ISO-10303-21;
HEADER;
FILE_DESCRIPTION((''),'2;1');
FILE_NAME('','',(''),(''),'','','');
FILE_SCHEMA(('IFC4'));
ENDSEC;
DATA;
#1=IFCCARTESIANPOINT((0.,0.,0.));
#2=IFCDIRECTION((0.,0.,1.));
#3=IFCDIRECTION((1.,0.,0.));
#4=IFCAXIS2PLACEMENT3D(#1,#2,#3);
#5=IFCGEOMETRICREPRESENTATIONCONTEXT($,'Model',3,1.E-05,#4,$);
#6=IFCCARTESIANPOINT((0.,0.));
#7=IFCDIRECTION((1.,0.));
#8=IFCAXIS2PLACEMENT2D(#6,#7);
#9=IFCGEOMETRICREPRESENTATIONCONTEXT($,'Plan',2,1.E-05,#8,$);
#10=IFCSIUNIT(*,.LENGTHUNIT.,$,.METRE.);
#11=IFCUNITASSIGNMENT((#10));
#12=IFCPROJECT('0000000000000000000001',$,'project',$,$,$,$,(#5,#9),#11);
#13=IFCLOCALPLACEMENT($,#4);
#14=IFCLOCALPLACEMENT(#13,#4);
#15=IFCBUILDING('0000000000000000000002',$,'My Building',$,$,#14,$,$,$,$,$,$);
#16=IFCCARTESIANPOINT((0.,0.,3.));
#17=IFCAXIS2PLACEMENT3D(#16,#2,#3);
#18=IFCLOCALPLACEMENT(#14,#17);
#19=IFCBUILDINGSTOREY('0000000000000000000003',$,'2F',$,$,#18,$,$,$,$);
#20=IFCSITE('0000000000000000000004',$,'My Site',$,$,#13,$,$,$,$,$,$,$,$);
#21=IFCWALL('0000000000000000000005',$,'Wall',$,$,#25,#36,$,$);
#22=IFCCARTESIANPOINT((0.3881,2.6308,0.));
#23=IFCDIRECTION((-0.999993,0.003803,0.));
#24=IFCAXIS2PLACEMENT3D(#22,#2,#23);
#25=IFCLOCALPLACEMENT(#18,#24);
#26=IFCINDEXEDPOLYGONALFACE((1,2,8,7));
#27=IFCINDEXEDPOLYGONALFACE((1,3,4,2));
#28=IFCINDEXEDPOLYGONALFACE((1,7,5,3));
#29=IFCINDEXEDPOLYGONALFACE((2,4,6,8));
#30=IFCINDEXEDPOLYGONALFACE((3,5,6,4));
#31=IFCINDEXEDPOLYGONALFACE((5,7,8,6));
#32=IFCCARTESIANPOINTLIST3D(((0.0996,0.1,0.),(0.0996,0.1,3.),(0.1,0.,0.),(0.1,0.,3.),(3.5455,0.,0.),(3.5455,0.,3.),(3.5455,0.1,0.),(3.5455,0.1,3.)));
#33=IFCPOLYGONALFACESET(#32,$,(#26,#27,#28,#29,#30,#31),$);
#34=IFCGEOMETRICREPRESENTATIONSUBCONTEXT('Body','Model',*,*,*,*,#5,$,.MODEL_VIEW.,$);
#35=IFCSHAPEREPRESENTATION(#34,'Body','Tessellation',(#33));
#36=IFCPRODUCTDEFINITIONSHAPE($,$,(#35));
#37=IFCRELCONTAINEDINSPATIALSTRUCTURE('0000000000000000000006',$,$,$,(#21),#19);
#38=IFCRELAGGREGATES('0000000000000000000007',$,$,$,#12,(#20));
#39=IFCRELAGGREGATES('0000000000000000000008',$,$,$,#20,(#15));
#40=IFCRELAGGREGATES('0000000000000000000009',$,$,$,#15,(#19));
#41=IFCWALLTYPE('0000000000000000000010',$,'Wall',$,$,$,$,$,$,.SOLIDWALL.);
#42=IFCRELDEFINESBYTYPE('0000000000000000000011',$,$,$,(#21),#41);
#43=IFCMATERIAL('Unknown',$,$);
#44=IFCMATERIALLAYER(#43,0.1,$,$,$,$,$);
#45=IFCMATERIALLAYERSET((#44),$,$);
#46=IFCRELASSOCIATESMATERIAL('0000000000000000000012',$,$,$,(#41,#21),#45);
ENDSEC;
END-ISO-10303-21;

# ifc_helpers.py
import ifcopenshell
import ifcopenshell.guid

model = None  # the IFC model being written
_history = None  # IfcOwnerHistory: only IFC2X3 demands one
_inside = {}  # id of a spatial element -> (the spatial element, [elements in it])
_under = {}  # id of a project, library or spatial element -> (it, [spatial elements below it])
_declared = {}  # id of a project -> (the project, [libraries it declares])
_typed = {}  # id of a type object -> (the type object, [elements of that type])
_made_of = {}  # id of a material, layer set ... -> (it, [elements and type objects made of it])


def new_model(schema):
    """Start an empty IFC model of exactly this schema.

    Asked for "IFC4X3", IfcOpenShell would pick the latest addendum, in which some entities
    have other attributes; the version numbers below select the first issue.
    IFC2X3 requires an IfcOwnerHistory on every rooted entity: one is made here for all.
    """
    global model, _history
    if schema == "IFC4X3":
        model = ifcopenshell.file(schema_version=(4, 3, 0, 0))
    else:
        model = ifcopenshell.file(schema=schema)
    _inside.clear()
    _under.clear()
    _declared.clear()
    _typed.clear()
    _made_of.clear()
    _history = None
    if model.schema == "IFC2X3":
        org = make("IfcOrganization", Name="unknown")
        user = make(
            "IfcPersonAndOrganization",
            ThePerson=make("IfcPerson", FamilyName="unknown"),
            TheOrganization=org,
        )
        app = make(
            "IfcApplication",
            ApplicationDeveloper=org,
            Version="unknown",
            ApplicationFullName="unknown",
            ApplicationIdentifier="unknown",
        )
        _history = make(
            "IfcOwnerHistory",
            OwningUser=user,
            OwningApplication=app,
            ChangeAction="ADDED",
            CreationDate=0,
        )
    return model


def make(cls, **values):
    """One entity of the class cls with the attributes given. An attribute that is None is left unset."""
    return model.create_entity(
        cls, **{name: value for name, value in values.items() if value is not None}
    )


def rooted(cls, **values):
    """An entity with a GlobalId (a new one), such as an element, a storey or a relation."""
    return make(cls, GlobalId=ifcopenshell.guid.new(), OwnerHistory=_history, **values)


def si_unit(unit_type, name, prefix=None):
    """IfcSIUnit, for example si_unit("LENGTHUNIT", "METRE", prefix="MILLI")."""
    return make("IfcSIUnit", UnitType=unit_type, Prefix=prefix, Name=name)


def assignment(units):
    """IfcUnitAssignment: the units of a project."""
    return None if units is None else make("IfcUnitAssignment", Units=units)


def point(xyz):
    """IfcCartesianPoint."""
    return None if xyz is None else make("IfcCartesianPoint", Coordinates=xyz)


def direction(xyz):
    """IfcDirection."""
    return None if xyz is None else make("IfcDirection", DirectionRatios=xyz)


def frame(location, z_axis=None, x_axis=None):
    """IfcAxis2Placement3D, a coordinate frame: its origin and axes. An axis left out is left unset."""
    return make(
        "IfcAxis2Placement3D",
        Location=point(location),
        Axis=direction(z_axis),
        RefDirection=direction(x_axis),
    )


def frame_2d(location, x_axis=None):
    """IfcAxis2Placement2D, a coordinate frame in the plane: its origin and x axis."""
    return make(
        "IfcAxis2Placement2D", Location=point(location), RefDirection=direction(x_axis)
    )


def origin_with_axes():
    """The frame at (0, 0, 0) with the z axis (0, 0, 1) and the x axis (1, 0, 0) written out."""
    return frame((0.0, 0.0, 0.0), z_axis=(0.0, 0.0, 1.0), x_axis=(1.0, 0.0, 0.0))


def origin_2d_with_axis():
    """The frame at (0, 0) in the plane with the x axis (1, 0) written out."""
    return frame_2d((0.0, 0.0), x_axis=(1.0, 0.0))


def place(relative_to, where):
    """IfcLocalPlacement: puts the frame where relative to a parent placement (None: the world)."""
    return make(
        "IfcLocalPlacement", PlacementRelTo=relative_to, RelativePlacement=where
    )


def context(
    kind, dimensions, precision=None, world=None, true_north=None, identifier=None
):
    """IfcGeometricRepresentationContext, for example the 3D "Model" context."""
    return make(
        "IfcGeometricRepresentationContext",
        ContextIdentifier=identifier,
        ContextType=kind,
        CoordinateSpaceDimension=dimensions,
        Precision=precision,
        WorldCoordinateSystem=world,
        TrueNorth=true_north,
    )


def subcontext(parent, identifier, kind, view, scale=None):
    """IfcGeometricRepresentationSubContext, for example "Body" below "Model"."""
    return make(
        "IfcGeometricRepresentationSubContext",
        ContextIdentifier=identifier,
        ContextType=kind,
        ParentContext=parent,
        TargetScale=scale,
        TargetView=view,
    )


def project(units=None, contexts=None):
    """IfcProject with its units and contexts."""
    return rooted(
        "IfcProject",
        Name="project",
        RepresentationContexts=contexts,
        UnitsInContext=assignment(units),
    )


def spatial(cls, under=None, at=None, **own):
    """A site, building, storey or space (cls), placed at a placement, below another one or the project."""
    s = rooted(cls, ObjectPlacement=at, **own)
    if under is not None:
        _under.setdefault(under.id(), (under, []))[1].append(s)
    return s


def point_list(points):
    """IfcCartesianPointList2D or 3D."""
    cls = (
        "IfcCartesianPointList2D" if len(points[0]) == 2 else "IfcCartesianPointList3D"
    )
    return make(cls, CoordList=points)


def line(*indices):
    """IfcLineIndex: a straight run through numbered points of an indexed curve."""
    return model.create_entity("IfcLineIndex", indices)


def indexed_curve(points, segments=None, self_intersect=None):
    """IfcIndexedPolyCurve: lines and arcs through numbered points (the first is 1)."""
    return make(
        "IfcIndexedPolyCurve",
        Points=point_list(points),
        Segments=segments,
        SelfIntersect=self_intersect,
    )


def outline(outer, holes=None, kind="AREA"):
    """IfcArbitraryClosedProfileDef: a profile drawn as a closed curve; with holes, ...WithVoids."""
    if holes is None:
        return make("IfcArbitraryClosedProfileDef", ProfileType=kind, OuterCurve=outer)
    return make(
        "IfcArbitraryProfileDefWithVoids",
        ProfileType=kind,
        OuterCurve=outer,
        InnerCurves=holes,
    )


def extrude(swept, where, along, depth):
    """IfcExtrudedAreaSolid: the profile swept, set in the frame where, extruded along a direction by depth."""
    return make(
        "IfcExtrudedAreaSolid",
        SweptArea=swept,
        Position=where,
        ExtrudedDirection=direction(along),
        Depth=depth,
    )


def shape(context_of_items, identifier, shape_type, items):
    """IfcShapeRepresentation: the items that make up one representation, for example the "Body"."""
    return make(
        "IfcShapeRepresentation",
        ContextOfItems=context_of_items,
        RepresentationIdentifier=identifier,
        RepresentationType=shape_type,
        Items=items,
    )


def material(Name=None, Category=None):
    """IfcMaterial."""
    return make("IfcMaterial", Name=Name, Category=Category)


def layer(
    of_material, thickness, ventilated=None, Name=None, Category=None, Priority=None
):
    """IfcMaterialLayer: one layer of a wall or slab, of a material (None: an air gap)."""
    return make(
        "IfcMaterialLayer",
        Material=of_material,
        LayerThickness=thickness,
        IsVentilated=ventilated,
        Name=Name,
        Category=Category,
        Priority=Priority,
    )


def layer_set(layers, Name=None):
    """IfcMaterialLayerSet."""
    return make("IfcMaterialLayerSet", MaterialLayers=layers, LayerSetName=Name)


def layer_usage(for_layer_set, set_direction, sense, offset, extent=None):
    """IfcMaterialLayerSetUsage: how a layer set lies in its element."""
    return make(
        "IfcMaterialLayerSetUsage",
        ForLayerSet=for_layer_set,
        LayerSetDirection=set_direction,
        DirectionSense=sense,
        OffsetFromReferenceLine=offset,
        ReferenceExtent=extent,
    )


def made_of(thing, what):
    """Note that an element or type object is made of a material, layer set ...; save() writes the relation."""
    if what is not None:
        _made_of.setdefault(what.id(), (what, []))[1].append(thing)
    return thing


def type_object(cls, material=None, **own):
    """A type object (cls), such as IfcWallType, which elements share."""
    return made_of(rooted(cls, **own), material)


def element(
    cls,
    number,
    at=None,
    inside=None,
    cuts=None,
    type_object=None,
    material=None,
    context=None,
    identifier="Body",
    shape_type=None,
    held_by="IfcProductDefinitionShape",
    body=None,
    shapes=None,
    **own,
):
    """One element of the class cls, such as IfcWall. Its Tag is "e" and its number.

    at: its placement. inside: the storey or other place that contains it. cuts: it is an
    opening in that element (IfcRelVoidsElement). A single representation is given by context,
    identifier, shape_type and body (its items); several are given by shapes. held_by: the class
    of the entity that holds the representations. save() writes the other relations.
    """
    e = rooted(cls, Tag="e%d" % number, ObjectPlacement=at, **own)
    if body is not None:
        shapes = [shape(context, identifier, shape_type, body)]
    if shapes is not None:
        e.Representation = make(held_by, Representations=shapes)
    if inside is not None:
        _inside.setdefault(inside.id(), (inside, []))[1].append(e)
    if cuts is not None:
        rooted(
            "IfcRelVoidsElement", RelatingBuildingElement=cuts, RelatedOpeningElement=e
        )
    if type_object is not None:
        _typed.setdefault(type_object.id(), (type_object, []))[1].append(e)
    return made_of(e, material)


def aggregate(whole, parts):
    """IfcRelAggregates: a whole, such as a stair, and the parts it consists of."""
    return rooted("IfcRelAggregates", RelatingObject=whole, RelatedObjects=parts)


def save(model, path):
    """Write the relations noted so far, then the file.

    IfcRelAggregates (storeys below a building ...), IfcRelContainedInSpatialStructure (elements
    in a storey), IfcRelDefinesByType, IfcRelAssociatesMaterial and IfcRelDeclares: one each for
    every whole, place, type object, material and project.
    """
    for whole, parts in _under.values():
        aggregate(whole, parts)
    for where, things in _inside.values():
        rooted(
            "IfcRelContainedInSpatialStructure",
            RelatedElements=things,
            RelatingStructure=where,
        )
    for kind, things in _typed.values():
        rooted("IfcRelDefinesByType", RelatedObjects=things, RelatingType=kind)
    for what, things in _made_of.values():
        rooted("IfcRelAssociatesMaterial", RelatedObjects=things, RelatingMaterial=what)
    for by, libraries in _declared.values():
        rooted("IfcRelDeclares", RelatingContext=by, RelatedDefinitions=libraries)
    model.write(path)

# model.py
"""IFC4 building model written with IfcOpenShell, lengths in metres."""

from ifc_helpers import new_model, si_unit, frame, origin_with_axes, origin_2d_with_axis, place, context, subcontext, project, spatial, line, indexed_curve, outline, extrude, material, layer, layer_set, layer_usage, type_object, element, save


model = new_model("IFC4")

# Units and contexts
model_context = context("Model", 3, precision=1e-05, world=origin_with_axes())
plan_context = context("Plan", 2, precision=1e-05, world=origin_2d_with_axis())
body_context_1 = subcontext(model_context, "Body", "Model", "MODEL_VIEW")
ifc_project = project(units=[si_unit("LENGTHUNIT", "METRE")], contexts=[model_context, plan_context])

# Site, building, storey
site_placement = place(None, origin_with_axes())
site = spatial("IfcSite", under=ifc_project, at=site_placement, Name="My Site")
building_placement = place(site_placement, origin_with_axes())
building = spatial("IfcBuilding", under=site, at=building_placement, Name="My Building")
storey_placement = place(building_placement, frame((0.0, 0.0, 3.0), z_axis=(0.0, 0.0, 1.0), x_axis=(1.0, 0.0, 0.0)))
storey = spatial("IfcBuildingStorey", under=building, at=storey_placement, Name="2F")

# Shared definitions
ifc_material = material(Name="Unknown")
ifc_layer = layer(ifc_material, 0.1)
ifc_layer_set = layer_set([ifc_layer])
wall_type = type_object("IfcWallType", Name="Wall", PredefinedType="SOLIDWALL", material=ifc_layer_set)

# Wall
ifc_layer_usage_1 = layer_usage(ifc_layer_set, "AXIS2", "POSITIVE", 0.0)
wall_1_placement = place(storey_placement, frame((0.3881, 2.6308, 0.0), z_axis=(0.0, 0.0, 1.0), x_axis=(-0.999993, 0.003803, 0.0)))
element("IfcWall", 1, at=wall_1_placement, inside=storey, type_object=wall_type, material=ifc_layer_usage_1, Name="Wall", context=body_context_1, shape_type="SweptSolid", body=[
    extrude(outline(indexed_curve([(0.1, 0.0), (0.0996, 0.1), (3.5455, 0.1), (3.5455, 0.0)], segments=[line(1, 2, 3, 4, 1)])), origin_with_axes(), (0.0, 0.0, 1.0), 3.0),
])

save(model, "model.ifc")
